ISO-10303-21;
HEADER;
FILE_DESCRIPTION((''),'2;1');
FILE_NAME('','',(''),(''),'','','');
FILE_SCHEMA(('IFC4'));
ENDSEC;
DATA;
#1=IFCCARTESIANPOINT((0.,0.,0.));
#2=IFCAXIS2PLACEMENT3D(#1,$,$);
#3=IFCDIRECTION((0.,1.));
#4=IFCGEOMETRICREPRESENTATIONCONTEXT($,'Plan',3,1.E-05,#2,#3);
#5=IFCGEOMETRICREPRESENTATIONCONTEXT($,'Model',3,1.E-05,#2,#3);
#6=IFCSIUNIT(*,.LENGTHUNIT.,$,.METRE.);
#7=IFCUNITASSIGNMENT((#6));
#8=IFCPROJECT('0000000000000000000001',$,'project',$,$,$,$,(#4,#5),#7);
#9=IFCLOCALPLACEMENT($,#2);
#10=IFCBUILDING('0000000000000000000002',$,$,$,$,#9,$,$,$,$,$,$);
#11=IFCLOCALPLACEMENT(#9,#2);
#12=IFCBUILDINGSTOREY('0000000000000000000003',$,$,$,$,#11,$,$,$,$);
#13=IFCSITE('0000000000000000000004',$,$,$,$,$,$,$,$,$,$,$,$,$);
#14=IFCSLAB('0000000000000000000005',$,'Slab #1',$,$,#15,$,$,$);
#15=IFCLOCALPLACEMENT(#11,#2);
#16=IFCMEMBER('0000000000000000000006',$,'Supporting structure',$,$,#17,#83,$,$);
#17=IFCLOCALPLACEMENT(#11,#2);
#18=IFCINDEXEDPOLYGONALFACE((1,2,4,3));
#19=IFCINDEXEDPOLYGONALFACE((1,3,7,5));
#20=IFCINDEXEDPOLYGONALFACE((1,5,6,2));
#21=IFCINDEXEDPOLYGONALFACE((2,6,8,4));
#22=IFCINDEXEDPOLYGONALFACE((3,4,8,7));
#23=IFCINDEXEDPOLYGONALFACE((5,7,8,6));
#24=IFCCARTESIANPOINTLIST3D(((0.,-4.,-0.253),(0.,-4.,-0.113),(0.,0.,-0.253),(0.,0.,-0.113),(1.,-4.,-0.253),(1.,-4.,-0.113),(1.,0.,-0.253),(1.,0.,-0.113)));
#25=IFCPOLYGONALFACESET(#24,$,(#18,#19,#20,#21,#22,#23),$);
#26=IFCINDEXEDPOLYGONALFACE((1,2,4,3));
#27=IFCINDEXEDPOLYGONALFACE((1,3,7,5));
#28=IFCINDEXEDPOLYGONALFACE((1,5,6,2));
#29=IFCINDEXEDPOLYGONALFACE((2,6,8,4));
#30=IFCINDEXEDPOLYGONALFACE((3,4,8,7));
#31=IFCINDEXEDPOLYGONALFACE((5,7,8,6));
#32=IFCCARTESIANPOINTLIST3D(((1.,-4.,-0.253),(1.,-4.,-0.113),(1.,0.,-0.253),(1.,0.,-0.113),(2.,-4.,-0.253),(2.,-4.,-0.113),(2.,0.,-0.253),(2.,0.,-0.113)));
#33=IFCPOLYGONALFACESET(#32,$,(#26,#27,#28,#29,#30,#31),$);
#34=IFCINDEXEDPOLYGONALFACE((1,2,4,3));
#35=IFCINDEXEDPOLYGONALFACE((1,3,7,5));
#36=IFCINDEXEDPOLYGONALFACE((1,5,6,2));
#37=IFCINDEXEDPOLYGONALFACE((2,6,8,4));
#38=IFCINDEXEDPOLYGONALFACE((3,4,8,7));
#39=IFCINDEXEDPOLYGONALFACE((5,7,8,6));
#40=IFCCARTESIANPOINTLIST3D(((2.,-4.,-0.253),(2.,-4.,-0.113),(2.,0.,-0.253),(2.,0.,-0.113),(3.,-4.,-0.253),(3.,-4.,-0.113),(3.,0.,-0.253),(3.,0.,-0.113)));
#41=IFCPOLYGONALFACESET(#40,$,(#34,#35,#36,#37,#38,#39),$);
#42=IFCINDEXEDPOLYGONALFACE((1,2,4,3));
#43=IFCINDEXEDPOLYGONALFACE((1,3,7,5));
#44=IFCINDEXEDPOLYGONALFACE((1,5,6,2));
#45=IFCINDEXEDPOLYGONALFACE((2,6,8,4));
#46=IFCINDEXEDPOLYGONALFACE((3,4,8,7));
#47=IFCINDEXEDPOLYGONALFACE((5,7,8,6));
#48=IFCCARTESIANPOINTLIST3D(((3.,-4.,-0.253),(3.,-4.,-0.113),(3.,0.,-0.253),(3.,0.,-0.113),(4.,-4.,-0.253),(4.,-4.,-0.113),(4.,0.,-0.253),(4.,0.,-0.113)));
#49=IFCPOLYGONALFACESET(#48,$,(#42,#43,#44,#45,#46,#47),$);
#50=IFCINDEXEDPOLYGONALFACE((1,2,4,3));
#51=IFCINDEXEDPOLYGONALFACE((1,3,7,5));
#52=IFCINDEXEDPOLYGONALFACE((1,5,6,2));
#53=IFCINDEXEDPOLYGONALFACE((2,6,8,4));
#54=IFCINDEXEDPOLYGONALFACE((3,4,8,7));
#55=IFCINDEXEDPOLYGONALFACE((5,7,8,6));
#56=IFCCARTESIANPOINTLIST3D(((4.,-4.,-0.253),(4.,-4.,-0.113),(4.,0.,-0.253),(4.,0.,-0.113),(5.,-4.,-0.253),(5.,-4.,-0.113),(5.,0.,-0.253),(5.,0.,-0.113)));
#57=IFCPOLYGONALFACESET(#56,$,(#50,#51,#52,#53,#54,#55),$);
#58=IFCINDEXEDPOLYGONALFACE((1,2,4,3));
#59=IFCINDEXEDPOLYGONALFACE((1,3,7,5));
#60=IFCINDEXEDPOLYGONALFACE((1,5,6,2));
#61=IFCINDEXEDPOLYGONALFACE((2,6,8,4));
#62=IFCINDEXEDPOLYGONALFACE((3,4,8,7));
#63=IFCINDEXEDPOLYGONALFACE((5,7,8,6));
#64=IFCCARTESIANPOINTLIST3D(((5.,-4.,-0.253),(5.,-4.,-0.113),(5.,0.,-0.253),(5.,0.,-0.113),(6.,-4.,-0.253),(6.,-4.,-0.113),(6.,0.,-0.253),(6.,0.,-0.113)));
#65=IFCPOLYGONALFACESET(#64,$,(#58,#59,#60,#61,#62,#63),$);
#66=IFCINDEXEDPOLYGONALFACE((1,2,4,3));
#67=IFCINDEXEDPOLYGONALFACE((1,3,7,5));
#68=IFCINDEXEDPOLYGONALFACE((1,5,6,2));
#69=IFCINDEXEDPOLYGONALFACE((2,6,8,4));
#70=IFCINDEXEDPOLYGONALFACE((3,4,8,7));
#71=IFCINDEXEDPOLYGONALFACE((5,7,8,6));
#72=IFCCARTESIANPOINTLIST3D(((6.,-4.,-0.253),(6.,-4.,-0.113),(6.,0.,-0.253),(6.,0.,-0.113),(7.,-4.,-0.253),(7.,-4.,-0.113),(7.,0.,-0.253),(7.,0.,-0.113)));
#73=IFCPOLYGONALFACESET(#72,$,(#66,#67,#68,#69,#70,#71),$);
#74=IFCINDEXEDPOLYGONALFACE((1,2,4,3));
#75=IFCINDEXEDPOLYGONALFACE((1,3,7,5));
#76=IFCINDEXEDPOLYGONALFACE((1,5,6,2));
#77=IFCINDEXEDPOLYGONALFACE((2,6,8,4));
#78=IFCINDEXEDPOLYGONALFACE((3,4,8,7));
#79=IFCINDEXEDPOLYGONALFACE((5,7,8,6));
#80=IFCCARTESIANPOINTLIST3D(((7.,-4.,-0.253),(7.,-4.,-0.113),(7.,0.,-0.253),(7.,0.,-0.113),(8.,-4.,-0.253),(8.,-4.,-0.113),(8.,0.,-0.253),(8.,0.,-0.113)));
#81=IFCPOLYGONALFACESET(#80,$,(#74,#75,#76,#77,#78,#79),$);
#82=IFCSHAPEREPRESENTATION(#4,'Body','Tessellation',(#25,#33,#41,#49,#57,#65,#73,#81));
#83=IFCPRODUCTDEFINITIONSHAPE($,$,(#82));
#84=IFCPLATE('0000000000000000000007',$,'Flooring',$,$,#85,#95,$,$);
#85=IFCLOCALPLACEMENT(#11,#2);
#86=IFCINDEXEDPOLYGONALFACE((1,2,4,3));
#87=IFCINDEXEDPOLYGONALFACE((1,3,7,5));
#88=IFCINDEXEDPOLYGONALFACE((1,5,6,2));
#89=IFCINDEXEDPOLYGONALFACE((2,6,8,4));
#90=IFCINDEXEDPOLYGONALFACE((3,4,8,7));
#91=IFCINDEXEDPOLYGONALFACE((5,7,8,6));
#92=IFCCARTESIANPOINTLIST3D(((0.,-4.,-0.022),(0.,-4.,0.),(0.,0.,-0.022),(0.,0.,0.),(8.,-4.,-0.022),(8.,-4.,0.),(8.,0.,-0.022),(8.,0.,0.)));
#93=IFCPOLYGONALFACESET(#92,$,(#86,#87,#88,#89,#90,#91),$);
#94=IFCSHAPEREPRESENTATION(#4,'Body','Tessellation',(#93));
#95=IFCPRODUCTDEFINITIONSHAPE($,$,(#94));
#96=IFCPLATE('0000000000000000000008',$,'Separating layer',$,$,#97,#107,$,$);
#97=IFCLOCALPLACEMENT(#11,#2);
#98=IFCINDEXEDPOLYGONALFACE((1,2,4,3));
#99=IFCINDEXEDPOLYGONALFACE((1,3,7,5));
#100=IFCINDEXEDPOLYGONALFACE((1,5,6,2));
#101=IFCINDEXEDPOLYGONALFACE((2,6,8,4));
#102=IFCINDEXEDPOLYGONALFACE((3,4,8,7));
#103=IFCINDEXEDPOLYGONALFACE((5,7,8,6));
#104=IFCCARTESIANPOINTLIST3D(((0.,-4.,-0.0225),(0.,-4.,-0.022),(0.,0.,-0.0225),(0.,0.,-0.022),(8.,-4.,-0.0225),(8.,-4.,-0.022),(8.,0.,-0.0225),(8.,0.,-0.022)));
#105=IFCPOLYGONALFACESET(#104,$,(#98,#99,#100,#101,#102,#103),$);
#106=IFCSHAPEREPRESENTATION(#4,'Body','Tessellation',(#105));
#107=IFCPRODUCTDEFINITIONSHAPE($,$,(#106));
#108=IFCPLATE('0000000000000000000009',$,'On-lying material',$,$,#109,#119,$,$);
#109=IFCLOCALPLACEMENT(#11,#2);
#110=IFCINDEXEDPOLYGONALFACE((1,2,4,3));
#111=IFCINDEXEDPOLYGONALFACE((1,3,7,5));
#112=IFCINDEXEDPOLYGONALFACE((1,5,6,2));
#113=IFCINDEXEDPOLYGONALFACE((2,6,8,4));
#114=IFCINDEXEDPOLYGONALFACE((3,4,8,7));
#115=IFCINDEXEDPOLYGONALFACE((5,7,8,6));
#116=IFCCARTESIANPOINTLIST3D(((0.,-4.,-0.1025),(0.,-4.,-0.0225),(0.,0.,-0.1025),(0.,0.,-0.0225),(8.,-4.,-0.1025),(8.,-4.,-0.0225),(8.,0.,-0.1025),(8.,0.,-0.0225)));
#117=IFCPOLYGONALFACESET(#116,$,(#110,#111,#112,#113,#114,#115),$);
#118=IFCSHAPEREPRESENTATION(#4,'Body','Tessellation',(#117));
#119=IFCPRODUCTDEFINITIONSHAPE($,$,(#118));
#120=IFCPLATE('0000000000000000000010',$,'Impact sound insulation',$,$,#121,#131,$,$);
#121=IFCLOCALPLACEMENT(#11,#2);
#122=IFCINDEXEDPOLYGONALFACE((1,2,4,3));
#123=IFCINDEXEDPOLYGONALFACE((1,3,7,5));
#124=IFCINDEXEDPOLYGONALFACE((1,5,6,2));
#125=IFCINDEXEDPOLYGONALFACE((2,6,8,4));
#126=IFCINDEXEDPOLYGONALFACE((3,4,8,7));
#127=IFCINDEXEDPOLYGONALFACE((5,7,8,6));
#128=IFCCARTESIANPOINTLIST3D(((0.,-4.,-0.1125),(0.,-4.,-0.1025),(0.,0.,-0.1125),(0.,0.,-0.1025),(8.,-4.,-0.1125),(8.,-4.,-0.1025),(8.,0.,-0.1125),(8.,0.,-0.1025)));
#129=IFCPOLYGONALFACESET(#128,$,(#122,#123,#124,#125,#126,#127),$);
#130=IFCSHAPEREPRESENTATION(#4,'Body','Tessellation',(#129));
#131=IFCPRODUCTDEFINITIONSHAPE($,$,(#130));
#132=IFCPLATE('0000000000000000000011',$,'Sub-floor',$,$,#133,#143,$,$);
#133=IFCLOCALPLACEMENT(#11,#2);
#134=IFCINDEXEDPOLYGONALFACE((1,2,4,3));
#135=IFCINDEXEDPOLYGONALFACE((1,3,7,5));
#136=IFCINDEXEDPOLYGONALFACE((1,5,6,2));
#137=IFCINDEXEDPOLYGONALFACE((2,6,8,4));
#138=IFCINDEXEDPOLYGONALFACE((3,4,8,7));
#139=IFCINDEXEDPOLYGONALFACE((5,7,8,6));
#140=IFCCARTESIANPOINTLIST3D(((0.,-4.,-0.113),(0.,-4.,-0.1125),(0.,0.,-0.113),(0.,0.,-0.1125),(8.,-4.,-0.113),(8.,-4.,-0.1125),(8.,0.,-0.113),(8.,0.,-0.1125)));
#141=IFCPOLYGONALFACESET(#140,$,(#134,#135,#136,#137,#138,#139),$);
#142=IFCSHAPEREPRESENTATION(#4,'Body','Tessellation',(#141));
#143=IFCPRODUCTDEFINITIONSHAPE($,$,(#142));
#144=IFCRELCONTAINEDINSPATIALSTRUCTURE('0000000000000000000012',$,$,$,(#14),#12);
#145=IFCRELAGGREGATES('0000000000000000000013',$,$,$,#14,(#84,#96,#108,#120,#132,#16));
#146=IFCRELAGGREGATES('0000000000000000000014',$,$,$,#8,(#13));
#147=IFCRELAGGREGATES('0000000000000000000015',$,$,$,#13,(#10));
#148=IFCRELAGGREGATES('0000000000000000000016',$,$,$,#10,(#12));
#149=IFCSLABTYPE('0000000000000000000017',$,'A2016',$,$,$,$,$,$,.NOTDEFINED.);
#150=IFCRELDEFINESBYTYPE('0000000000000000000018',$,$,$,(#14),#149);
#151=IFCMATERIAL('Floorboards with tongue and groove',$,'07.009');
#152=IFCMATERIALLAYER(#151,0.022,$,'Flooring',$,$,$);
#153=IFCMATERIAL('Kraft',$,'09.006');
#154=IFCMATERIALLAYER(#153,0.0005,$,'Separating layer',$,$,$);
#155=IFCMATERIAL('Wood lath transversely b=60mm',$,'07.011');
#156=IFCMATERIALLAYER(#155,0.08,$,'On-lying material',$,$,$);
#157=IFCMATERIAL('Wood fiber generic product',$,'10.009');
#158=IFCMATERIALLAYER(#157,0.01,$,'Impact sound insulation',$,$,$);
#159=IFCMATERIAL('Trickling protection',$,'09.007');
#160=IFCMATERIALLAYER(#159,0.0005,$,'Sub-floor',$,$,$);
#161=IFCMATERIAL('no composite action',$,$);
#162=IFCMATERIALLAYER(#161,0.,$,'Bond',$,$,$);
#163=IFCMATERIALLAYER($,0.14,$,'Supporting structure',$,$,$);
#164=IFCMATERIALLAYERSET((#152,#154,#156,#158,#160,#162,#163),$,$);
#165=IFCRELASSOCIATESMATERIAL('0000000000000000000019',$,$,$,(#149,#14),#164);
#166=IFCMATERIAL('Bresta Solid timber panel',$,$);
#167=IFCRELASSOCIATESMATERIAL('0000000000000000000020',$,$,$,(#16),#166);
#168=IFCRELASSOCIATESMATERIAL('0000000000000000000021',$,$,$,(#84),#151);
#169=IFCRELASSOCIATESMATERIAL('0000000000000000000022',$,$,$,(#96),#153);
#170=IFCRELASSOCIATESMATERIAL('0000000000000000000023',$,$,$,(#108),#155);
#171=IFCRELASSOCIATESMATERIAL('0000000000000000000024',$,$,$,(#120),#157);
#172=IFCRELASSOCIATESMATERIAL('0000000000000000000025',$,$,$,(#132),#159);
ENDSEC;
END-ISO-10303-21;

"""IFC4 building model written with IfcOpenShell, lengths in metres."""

from ifc_helpers import new_model, si_unit, direction, frame, frame_2d, origin, origin_with_axes, place, context, project, spatial, rectangle, extrude, material, layer, layer_set, type_object, element, aggregate, save


model = new_model("IFC4")

# Units and contexts
plan_context = context("Plan", 3, precision=1e-05, world=origin(), true_north=direction((0.0, 1.0)))
model_context = context("Model", 3, precision=1e-05, world=origin(), true_north=direction((0.0, 1.0)))
ifc_project = project(units=[si_unit("LENGTHUNIT", "METRE")], contexts=[plan_context, model_context])

# Site, building, storey
site = spatial("IfcSite", under=ifc_project)
building_placement = place(None, origin())
building = spatial("IfcBuilding", under=site, at=building_placement)
storey_placement = place(building_placement, origin())
storey = spatial("IfcBuildingStorey", under=building, at=storey_placement)

# Slab, member, plates
ifc_material_1 = material(Name="Floorboards with tongue and groove", Category="07.009")
ifc_layer_1 = layer(ifc_material_1, 0.022, Name="Flooring")
ifc_material_2 = material(Name="Kraft", Category="09.006")
ifc_layer_2 = layer(ifc_material_2, 0.0005, Name="Separating layer")
ifc_material_3 = material(Name="Wood lath transversely b=60mm", Category="07.011")
ifc_layer_3 = layer(ifc_material_3, 0.08, Name="On-lying material")
ifc_material_4 = material(Name="Wood fiber generic product", Category="10.009")
ifc_layer_4 = layer(ifc_material_4, 0.01, Name="Impact sound insulation")
ifc_material_5 = material(Name="Trickling protection", Category="09.007")
ifc_layer_5 = layer(ifc_material_5, 0.0005, Name="Sub-floor")
ifc_material_6 = material(Name="no composite action")
ifc_layer_6 = layer(ifc_material_6, 0.0, Name="Bond")
ifc_layer_7 = layer(None, 0.14, Name="Supporting structure")
ifc_layer_set = layer_set([ifc_layer_1, ifc_layer_2, ifc_layer_3, ifc_layer_4, ifc_layer_5, ifc_layer_6, ifc_layer_7])
slab_type = type_object("IfcSlabType", Name="A2016", PredefinedType="NOTDEFINED", material=ifc_layer_set)
slab_placement = place(None, frame((0.0, 0.0, 0.0), z_axis=(0.0, 0.0, -1.0), x_axis=(1.0, 0.0, 0.0)))
slab = element("IfcSlab", 1, at=slab_placement, inside=storey, type_object=slab_type, material=ifc_layer_set, Name="Slab #1")
ifc_material_7 = material(Name="Bresta Solid timber panel")
member_placement = place(slab_placement, origin())
member = element("IfcMember", 2, at=member_placement, material=ifc_material_7, Name="Supporting structure", context=plan_context, shape_type="SweptSolid", body=[
    extrude(rectangle(XDim=1.0, YDim=0.14, at=frame_2d((0.5, 0.07), x_axis=(1.0, 0.0))), frame((0.0, 4.0, 0.113), z_axis=(0.0, -1.0, 0.0), x_axis=(1.0, 0.0, 0.0)), (0.0, 0.0, 1.0), 4.0),
    extrude(rectangle(XDim=1.0, YDim=0.14, at=frame_2d((0.5, 0.07), x_axis=(1.0, 0.0))), frame((1.0, 4.0, 0.113), z_axis=(0.0, -1.0, 0.0), x_axis=(1.0, 0.0, 0.0)), (0.0, 0.0, 1.0), 4.0),
    extrude(rectangle(XDim=1.0, YDim=0.14, at=frame_2d((0.5, 0.07), x_axis=(1.0, 0.0))), frame((2.0, 4.0, 0.113), z_axis=(0.0, -1.0, 0.0), x_axis=(1.0, 0.0, 0.0)), (0.0, 0.0, 1.0), 4.0),
    extrude(rectangle(XDim=1.0, YDim=0.14, at=frame_2d((0.5, 0.07), x_axis=(1.0, 0.0))), frame((3.0, 4.0, 0.113), z_axis=(0.0, -1.0, 0.0), x_axis=(1.0, 0.0, 0.0)), (0.0, 0.0, 1.0), 4.0),
    extrude(rectangle(XDim=1.0, YDim=0.14, at=frame_2d((0.5, 0.07), x_axis=(1.0, 0.0))), frame((4.0, 4.0, 0.113), z_axis=(0.0, -1.0, 0.0), x_axis=(1.0, 0.0, 0.0)), (0.0, 0.0, 1.0), 4.0),
    extrude(rectangle(XDim=1.0, YDim=0.14, at=frame_2d((0.5, 0.07), x_axis=(1.0, 0.0))), frame((5.0, 4.0, 0.113), z_axis=(0.0, -1.0, 0.0), x_axis=(1.0, 0.0, 0.0)), (0.0, 0.0, 1.0), 4.0),
    extrude(rectangle(XDim=1.0, YDim=0.14, at=frame_2d((0.5, 0.07), x_axis=(1.0, 0.0))), frame((6.0, 4.0, 0.113), z_axis=(0.0, -1.0, 0.0), x_axis=(1.0, 0.0, 0.0)), (0.0, 0.0, 1.0), 4.0),
    extrude(rectangle(XDim=1.0, YDim=0.14, at=frame_2d((0.5, 0.07), x_axis=(1.0, 0.0))), frame((7.0, 4.0, 0.113), z_axis=(0.0, -1.0, 0.0), x_axis=(1.0, 0.0, 0.0)), (0.0, 0.0, 1.0), 4.0),
])
plate_1_placement = place(slab_placement, origin())
plate_1 = element("IfcPlate", 3, at=plate_1_placement, material=ifc_material_1, Name="Flooring", context=plan_context, shape_type="SweptSolid", body=[
    extrude(rectangle(XDim=8.0, YDim=4.0, at=frame_2d((4.0, 2.0), x_axis=(1.0, 0.0))), origin_with_axes(), (0.0, 0.0, 1.0), 0.022),
])
plate_2_placement = place(slab_placement, origin())
plate_2 = element("IfcPlate", 4, at=plate_2_placement, material=ifc_material_2, Name="Separating layer", context=plan_context, shape_type="SweptSolid", body=[
    extrude(rectangle(XDim=8.0, YDim=4.0, at=frame_2d((4.0, 2.0), x_axis=(1.0, 0.0))), frame((0.0, 0.0, 0.022), z_axis=(0.0, 0.0, 1.0), x_axis=(1.0, 0.0, 0.0)), (0.0, 0.0, 1.0), 0.0005),
])
plate_3_placement = place(slab_placement, origin())
plate_3 = element("IfcPlate", 5, at=plate_3_placement, material=ifc_material_3, Name="On-lying material", context=plan_context, shape_type="SweptSolid", body=[
    extrude(rectangle(XDim=8.0, YDim=4.0, at=frame_2d((4.0, 2.0), x_axis=(1.0, 0.0))), frame((0.0, 0.0, 0.0225), z_axis=(0.0, 0.0, 1.0), x_axis=(1.0, 0.0, 0.0)), (0.0, 0.0, 1.0), 0.08),
])
plate_4_placement = place(slab_placement, origin())
plate_4 = element("IfcPlate", 6, at=plate_4_placement, material=ifc_material_4, Name="Impact sound insulation", context=plan_context, shape_type="SweptSolid", body=[
    extrude(rectangle(XDim=8.0, YDim=4.0, at=frame_2d((4.0, 2.0), x_axis=(1.0, 0.0))), frame((0.0, 0.0, 0.1025), z_axis=(0.0, 0.0, 1.0), x_axis=(1.0, 0.0, 0.0)), (0.0, 0.0, 1.0), 0.01),
])
plate_5_placement = place(slab_placement, origin())
plate_5 = element("IfcPlate", 7, at=plate_5_placement, material=ifc_material_5, Name="Sub-floor", context=plan_context, shape_type="SweptSolid", body=[
    extrude(rectangle(XDim=8.0, YDim=4.0, at=frame_2d((4.0, 2.0), x_axis=(1.0, 0.0))), frame((0.0, 0.0, 0.1125), z_axis=(0.0, 0.0, 1.0), x_axis=(1.0, 0.0, 0.0)), (0.0, 0.0, 1.0), 0.0005),
])
aggregate(slab, [plate_1, plate_2, plate_3, plate_4, plate_5, member])

save(model, "model.ifc")
